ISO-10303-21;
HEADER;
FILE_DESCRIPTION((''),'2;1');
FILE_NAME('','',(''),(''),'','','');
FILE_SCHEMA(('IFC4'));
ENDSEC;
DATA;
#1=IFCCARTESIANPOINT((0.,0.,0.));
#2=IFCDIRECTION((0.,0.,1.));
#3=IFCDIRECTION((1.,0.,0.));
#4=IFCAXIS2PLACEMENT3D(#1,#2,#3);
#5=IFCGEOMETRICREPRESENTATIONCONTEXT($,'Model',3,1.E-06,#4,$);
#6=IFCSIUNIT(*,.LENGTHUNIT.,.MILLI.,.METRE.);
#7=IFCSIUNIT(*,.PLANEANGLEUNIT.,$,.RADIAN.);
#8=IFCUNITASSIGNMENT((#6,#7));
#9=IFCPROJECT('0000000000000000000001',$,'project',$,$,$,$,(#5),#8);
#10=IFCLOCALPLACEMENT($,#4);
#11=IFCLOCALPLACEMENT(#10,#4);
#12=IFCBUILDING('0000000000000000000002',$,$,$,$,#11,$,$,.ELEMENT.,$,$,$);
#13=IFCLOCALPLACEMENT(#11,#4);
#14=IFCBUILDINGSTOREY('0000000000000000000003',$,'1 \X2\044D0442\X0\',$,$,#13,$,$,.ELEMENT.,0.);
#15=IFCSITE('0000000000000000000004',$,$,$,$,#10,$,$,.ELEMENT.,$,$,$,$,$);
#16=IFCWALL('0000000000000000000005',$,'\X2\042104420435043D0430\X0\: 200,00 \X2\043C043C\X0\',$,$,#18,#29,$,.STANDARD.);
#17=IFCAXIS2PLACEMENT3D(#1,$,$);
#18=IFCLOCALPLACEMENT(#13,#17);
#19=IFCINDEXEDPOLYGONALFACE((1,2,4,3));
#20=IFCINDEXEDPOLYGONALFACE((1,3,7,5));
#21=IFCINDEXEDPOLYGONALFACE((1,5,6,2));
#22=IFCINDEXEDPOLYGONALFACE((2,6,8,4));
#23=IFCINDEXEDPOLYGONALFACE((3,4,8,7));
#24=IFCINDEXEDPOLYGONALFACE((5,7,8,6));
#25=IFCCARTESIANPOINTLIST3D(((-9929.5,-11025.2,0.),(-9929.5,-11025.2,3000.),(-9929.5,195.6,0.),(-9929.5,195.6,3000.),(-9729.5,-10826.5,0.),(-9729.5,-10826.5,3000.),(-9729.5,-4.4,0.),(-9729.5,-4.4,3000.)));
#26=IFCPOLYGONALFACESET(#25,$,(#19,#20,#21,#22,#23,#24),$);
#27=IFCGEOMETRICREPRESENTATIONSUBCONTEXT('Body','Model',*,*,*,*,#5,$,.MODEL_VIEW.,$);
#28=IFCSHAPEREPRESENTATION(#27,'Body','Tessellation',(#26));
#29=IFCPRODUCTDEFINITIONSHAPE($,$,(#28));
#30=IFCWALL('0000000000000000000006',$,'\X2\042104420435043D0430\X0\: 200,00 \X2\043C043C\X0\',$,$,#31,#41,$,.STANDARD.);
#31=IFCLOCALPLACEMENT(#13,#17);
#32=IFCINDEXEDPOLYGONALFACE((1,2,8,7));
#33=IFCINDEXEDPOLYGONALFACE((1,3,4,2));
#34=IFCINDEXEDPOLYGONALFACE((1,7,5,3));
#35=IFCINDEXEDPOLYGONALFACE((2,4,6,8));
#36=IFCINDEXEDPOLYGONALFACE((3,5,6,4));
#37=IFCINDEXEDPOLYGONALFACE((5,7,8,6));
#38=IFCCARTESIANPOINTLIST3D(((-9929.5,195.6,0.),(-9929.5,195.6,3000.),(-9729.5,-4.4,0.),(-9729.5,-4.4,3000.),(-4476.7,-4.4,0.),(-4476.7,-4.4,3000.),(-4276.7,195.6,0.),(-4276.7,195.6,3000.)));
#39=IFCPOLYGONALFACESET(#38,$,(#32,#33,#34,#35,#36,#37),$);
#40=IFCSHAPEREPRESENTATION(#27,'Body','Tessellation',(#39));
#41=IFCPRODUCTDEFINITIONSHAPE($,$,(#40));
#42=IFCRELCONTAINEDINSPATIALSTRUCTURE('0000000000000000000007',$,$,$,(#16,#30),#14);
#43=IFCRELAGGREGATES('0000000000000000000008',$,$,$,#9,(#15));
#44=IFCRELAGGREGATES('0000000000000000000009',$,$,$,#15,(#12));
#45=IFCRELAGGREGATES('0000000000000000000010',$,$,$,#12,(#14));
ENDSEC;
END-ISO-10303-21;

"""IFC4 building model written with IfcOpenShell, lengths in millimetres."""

from ifc_helpers import new_model, si_unit, frame, origin_with_axes, place, context, subcontext, project, spatial, line, indexed_curve, outline, extrude, source, transform, mapped, element, save


model = new_model("IFC4")

# Units and contexts
model_context = context("Model", 3, precision=1e-06, world=origin_with_axes())
body_context = subcontext(model_context, "Body", "Model", "MODEL_VIEW")
ifc_project = project(units=[si_unit("LENGTHUNIT", "METRE", prefix="MILLI"), si_unit("PLANEANGLEUNIT", "RADIAN")], contexts=[model_context])

# Site, building, storey
site_placement = place(None, origin_with_axes())
site = spatial("IfcSite", under=ifc_project, at=site_placement, CompositionType="ELEMENT")
building_placement = place(site_placement, origin_with_axes())
building = spatial("IfcBuilding", under=site, at=building_placement, CompositionType="ELEMENT")
storey_placement = place(building_placement, origin_with_axes())
storey = spatial("IfcBuildingStorey", under=building, at=storey_placement, Name="1 эт", CompositionType="ELEMENT", Elevation=0.0)

# Walls
shared_shape_1 = source(origin_with_axes(), body_context, "Body", "SweptSolid", [
    extrude(outline(indexed_curve([(99.4, -100.0), (10921.5, -100.0), (11121.5, 100.0), (-99.4, 100.0)], segments=[line(1, 2), line(2, 3), line(3, 4), line(4, 1)])), origin_with_axes(), (0.0, 0.0, 1.0), 3000.0),
])
wall_1_placement = place(storey_placement, frame((-9829.5, -10925.9, 0.0), z_axis=(0.0, 0.0, 1.0), x_axis=(0.0, 1.0, 0.0)))
element("IfcWall", 1, at=wall_1_placement, inside=storey, Name="Стена: 200,00 мм", PredefinedType="STANDARD", context=body_context, shape_type="MappedRepresentation", body=[
    mapped(shared_shape_1, transform((0.0, 0.0, 0.0), x_axis=(1.0, 0.0, 0.0), y_axis=(0.0, 1.0, 0.0), z_axis=(0.0, 0.0, 1.0), scale=1.0)),
])
shared_shape_2 = source(origin_with_axes(), body_context, "Body", "SweptSolid", [
    extrude(outline(indexed_curve([(100.0, -100.0), (5352.8, -100.0), (5552.8, 100.0), (-100.0, 100.0)], segments=[line(1, 2), line(2, 3), line(3, 4), line(4, 1)])), origin_with_axes(), (0.0, 0.0, 1.0), 3000.0),
])
wall_2_placement = place(storey_placement, frame((-9829.5, 95.6, 0.0), z_axis=(0.0, 0.0, 1.0), x_axis=(1.0, 0.0, 0.0)))
element("IfcWall", 2, at=wall_2_placement, inside=storey, Name="Стена: 200,00 мм", PredefinedType="STANDARD", context=body_context, shape_type="MappedRepresentation", body=[
    mapped(shared_shape_2, transform((0.0, 0.0, 0.0), x_axis=(1.0, 0.0, 0.0), y_axis=(0.0, 1.0, 0.0), z_axis=(0.0, 0.0, 1.0), scale=1.0)),
])

save(model, "model.ifc")
